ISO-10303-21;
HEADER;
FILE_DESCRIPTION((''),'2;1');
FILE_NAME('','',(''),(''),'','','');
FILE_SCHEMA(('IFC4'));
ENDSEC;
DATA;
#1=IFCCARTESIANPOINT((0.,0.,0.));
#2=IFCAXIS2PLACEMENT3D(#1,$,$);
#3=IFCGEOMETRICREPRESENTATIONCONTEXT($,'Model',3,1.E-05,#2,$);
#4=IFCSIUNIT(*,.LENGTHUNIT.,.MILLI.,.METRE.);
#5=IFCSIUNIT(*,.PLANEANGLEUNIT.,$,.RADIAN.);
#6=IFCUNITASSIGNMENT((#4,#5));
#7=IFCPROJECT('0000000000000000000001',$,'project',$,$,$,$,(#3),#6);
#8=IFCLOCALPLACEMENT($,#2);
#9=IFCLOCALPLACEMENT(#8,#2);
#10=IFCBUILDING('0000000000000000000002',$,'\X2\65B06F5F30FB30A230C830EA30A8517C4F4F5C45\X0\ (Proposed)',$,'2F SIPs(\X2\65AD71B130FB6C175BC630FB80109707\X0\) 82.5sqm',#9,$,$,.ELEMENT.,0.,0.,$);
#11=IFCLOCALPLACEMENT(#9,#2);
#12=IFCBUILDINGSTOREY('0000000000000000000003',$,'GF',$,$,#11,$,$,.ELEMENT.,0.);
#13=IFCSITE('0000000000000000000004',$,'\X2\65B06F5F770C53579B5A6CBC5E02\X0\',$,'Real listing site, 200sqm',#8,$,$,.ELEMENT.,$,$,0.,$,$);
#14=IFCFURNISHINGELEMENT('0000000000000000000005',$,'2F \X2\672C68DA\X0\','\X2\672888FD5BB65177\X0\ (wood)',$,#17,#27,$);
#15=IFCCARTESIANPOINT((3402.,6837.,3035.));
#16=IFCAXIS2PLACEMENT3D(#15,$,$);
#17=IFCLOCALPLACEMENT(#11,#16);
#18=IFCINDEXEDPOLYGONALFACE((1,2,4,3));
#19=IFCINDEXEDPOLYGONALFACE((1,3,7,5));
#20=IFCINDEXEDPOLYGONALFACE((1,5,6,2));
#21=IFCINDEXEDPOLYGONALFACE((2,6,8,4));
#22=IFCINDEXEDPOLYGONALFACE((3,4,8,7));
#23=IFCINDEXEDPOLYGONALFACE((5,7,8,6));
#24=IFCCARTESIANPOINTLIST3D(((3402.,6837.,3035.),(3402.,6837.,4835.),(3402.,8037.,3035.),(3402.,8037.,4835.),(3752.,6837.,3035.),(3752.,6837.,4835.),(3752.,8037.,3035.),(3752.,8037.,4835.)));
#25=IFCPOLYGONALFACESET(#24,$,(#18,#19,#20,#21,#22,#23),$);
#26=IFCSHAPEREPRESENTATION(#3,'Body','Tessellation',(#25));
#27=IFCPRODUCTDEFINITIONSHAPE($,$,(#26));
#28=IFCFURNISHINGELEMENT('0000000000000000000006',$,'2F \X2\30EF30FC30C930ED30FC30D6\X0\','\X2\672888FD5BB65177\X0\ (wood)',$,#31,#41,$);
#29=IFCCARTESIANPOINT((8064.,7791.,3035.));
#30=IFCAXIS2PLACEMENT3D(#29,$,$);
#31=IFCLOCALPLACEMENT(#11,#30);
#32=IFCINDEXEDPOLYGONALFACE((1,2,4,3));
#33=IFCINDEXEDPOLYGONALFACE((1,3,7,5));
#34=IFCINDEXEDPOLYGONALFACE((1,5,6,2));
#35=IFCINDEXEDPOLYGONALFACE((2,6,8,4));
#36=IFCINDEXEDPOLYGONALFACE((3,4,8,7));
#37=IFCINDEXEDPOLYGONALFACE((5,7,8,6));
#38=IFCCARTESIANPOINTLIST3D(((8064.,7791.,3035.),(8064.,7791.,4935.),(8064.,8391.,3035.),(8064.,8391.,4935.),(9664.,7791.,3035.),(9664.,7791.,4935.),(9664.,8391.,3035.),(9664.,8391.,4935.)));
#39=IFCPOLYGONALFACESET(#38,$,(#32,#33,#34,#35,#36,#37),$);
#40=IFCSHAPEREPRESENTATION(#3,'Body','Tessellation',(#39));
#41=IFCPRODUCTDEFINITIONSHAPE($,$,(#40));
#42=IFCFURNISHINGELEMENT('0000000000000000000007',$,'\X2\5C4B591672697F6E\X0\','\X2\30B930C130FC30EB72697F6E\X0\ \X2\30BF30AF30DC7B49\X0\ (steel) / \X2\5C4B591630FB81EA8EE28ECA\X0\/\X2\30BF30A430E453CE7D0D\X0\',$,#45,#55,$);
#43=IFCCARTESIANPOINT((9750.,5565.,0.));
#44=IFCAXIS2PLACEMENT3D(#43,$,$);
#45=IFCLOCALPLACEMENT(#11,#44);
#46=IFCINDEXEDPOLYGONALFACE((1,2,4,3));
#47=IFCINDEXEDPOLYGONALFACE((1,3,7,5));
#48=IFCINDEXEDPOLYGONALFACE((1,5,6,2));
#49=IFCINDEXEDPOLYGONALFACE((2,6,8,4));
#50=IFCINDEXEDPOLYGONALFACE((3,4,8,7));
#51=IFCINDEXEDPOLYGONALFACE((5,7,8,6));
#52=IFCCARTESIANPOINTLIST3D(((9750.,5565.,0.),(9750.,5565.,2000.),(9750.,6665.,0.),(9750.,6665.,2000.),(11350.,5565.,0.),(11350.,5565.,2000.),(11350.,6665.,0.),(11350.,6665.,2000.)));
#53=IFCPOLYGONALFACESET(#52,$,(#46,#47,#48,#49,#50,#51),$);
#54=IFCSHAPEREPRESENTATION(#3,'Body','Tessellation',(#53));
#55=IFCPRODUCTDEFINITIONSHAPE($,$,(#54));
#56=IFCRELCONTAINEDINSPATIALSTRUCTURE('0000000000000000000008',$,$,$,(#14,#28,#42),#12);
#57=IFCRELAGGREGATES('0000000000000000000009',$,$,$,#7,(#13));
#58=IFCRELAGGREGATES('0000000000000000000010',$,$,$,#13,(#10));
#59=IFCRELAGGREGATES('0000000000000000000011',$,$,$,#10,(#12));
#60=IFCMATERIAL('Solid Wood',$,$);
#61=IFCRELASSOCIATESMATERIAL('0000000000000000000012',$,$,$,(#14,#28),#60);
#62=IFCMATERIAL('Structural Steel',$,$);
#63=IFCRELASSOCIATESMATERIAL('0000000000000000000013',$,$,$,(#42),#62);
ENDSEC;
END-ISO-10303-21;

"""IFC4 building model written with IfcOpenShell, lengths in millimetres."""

from ifc_helpers import new_model, si_unit, frame, frame_2d, origin, place, context, project, spatial, rectangle, extrude, material, element, save


model = new_model("IFC4")

# Units and contexts
model_context = context("Model", 3, precision=1e-05, world=origin())
ifc_project = project(units=[si_unit("LENGTHUNIT", "METRE", prefix="MILLI"), si_unit("PLANEANGLEUNIT", "RADIAN")], contexts=[model_context])

# Site, building, storey
site_placement = place(None, origin())
site = spatial("IfcSite", under=ifc_project, at=site_placement, Name="新潟県南魚沼市", ObjectType="Real listing site, 200sqm", CompositionType="ELEMENT", RefElevation=0.0)
building_placement = place(site_placement, origin())
building = spatial("IfcBuilding", under=site, at=building_placement, Name="新潟・アトリエ兼住居 (Proposed)", ObjectType="2F SIPs(断熱・気密・耐震) 82.5sqm", CompositionType="ELEMENT", ElevationOfRefHeight=0.0, ElevationOfTerrain=0.0)
storey_placement = place(building_placement, origin())
storey = spatial("IfcBuildingStorey", under=building, at=storey_placement, Name="GF", CompositionType="ELEMENT", Elevation=0.0)

# Shared definitions
ifc_material_1 = material(Name="Solid Wood")

# Shared definitions
ifc_material_2 = material(Name="Structural Steel")

# Furnishing elements
furnishing_1_placement = place(storey_placement, frame((3402.0, 6837.0, 3035.0)))
element("IfcFurnishingElement", 1, at=furnishing_1_placement, inside=storey, material=ifc_material_1, Name="2F 本棚", Description="木製家具 (wood)", context=model_context, shape_type="SweptSolid", body=[
    extrude(rectangle(XDim=350.0, YDim=1200.0, at=frame_2d((175.0, 600.0))), frame((3402.0, 6837.0, 3035.0)), (0.0, 0.0, 1.0), 1800.0),
])
furnishing_2_placement = place(storey_placement, frame((8064.0, 7791.0, 3035.0)))
element("IfcFurnishingElement", 2, at=furnishing_2_placement, inside=storey, material=ifc_material_1, Name="2F ワードローブ", Description="木製家具 (wood)", context=model_context, shape_type="SweptSolid", body=[
    extrude(rectangle(XDim=1600.0, YDim=600.0, at=frame_2d((800.0, 300.0))), frame((8064.0, 7791.0, 3035.0)), (0.0, 0.0, 1.0), 1900.0),
])
furnishing_3_placement = place(storey_placement, frame((9750.0, 5565.0, 0.0)))
element("IfcFurnishingElement", 3, at=furnishing_3_placement, inside=storey, material=ifc_material_2, Name="屋外物置", Description="スチール物置 タクボ等 (steel) / 屋外・自転車/タイヤ収納", context=model_context, shape_type="SweptSolid", body=[
    extrude(rectangle(XDim=1600.0, YDim=1100.0, at=frame_2d((800.0, 550.0))), frame((9750.0, 5565.0, 0.0)), (0.0, 0.0, 1.0), 2000.0),
])

save(model, "model.ifc")
